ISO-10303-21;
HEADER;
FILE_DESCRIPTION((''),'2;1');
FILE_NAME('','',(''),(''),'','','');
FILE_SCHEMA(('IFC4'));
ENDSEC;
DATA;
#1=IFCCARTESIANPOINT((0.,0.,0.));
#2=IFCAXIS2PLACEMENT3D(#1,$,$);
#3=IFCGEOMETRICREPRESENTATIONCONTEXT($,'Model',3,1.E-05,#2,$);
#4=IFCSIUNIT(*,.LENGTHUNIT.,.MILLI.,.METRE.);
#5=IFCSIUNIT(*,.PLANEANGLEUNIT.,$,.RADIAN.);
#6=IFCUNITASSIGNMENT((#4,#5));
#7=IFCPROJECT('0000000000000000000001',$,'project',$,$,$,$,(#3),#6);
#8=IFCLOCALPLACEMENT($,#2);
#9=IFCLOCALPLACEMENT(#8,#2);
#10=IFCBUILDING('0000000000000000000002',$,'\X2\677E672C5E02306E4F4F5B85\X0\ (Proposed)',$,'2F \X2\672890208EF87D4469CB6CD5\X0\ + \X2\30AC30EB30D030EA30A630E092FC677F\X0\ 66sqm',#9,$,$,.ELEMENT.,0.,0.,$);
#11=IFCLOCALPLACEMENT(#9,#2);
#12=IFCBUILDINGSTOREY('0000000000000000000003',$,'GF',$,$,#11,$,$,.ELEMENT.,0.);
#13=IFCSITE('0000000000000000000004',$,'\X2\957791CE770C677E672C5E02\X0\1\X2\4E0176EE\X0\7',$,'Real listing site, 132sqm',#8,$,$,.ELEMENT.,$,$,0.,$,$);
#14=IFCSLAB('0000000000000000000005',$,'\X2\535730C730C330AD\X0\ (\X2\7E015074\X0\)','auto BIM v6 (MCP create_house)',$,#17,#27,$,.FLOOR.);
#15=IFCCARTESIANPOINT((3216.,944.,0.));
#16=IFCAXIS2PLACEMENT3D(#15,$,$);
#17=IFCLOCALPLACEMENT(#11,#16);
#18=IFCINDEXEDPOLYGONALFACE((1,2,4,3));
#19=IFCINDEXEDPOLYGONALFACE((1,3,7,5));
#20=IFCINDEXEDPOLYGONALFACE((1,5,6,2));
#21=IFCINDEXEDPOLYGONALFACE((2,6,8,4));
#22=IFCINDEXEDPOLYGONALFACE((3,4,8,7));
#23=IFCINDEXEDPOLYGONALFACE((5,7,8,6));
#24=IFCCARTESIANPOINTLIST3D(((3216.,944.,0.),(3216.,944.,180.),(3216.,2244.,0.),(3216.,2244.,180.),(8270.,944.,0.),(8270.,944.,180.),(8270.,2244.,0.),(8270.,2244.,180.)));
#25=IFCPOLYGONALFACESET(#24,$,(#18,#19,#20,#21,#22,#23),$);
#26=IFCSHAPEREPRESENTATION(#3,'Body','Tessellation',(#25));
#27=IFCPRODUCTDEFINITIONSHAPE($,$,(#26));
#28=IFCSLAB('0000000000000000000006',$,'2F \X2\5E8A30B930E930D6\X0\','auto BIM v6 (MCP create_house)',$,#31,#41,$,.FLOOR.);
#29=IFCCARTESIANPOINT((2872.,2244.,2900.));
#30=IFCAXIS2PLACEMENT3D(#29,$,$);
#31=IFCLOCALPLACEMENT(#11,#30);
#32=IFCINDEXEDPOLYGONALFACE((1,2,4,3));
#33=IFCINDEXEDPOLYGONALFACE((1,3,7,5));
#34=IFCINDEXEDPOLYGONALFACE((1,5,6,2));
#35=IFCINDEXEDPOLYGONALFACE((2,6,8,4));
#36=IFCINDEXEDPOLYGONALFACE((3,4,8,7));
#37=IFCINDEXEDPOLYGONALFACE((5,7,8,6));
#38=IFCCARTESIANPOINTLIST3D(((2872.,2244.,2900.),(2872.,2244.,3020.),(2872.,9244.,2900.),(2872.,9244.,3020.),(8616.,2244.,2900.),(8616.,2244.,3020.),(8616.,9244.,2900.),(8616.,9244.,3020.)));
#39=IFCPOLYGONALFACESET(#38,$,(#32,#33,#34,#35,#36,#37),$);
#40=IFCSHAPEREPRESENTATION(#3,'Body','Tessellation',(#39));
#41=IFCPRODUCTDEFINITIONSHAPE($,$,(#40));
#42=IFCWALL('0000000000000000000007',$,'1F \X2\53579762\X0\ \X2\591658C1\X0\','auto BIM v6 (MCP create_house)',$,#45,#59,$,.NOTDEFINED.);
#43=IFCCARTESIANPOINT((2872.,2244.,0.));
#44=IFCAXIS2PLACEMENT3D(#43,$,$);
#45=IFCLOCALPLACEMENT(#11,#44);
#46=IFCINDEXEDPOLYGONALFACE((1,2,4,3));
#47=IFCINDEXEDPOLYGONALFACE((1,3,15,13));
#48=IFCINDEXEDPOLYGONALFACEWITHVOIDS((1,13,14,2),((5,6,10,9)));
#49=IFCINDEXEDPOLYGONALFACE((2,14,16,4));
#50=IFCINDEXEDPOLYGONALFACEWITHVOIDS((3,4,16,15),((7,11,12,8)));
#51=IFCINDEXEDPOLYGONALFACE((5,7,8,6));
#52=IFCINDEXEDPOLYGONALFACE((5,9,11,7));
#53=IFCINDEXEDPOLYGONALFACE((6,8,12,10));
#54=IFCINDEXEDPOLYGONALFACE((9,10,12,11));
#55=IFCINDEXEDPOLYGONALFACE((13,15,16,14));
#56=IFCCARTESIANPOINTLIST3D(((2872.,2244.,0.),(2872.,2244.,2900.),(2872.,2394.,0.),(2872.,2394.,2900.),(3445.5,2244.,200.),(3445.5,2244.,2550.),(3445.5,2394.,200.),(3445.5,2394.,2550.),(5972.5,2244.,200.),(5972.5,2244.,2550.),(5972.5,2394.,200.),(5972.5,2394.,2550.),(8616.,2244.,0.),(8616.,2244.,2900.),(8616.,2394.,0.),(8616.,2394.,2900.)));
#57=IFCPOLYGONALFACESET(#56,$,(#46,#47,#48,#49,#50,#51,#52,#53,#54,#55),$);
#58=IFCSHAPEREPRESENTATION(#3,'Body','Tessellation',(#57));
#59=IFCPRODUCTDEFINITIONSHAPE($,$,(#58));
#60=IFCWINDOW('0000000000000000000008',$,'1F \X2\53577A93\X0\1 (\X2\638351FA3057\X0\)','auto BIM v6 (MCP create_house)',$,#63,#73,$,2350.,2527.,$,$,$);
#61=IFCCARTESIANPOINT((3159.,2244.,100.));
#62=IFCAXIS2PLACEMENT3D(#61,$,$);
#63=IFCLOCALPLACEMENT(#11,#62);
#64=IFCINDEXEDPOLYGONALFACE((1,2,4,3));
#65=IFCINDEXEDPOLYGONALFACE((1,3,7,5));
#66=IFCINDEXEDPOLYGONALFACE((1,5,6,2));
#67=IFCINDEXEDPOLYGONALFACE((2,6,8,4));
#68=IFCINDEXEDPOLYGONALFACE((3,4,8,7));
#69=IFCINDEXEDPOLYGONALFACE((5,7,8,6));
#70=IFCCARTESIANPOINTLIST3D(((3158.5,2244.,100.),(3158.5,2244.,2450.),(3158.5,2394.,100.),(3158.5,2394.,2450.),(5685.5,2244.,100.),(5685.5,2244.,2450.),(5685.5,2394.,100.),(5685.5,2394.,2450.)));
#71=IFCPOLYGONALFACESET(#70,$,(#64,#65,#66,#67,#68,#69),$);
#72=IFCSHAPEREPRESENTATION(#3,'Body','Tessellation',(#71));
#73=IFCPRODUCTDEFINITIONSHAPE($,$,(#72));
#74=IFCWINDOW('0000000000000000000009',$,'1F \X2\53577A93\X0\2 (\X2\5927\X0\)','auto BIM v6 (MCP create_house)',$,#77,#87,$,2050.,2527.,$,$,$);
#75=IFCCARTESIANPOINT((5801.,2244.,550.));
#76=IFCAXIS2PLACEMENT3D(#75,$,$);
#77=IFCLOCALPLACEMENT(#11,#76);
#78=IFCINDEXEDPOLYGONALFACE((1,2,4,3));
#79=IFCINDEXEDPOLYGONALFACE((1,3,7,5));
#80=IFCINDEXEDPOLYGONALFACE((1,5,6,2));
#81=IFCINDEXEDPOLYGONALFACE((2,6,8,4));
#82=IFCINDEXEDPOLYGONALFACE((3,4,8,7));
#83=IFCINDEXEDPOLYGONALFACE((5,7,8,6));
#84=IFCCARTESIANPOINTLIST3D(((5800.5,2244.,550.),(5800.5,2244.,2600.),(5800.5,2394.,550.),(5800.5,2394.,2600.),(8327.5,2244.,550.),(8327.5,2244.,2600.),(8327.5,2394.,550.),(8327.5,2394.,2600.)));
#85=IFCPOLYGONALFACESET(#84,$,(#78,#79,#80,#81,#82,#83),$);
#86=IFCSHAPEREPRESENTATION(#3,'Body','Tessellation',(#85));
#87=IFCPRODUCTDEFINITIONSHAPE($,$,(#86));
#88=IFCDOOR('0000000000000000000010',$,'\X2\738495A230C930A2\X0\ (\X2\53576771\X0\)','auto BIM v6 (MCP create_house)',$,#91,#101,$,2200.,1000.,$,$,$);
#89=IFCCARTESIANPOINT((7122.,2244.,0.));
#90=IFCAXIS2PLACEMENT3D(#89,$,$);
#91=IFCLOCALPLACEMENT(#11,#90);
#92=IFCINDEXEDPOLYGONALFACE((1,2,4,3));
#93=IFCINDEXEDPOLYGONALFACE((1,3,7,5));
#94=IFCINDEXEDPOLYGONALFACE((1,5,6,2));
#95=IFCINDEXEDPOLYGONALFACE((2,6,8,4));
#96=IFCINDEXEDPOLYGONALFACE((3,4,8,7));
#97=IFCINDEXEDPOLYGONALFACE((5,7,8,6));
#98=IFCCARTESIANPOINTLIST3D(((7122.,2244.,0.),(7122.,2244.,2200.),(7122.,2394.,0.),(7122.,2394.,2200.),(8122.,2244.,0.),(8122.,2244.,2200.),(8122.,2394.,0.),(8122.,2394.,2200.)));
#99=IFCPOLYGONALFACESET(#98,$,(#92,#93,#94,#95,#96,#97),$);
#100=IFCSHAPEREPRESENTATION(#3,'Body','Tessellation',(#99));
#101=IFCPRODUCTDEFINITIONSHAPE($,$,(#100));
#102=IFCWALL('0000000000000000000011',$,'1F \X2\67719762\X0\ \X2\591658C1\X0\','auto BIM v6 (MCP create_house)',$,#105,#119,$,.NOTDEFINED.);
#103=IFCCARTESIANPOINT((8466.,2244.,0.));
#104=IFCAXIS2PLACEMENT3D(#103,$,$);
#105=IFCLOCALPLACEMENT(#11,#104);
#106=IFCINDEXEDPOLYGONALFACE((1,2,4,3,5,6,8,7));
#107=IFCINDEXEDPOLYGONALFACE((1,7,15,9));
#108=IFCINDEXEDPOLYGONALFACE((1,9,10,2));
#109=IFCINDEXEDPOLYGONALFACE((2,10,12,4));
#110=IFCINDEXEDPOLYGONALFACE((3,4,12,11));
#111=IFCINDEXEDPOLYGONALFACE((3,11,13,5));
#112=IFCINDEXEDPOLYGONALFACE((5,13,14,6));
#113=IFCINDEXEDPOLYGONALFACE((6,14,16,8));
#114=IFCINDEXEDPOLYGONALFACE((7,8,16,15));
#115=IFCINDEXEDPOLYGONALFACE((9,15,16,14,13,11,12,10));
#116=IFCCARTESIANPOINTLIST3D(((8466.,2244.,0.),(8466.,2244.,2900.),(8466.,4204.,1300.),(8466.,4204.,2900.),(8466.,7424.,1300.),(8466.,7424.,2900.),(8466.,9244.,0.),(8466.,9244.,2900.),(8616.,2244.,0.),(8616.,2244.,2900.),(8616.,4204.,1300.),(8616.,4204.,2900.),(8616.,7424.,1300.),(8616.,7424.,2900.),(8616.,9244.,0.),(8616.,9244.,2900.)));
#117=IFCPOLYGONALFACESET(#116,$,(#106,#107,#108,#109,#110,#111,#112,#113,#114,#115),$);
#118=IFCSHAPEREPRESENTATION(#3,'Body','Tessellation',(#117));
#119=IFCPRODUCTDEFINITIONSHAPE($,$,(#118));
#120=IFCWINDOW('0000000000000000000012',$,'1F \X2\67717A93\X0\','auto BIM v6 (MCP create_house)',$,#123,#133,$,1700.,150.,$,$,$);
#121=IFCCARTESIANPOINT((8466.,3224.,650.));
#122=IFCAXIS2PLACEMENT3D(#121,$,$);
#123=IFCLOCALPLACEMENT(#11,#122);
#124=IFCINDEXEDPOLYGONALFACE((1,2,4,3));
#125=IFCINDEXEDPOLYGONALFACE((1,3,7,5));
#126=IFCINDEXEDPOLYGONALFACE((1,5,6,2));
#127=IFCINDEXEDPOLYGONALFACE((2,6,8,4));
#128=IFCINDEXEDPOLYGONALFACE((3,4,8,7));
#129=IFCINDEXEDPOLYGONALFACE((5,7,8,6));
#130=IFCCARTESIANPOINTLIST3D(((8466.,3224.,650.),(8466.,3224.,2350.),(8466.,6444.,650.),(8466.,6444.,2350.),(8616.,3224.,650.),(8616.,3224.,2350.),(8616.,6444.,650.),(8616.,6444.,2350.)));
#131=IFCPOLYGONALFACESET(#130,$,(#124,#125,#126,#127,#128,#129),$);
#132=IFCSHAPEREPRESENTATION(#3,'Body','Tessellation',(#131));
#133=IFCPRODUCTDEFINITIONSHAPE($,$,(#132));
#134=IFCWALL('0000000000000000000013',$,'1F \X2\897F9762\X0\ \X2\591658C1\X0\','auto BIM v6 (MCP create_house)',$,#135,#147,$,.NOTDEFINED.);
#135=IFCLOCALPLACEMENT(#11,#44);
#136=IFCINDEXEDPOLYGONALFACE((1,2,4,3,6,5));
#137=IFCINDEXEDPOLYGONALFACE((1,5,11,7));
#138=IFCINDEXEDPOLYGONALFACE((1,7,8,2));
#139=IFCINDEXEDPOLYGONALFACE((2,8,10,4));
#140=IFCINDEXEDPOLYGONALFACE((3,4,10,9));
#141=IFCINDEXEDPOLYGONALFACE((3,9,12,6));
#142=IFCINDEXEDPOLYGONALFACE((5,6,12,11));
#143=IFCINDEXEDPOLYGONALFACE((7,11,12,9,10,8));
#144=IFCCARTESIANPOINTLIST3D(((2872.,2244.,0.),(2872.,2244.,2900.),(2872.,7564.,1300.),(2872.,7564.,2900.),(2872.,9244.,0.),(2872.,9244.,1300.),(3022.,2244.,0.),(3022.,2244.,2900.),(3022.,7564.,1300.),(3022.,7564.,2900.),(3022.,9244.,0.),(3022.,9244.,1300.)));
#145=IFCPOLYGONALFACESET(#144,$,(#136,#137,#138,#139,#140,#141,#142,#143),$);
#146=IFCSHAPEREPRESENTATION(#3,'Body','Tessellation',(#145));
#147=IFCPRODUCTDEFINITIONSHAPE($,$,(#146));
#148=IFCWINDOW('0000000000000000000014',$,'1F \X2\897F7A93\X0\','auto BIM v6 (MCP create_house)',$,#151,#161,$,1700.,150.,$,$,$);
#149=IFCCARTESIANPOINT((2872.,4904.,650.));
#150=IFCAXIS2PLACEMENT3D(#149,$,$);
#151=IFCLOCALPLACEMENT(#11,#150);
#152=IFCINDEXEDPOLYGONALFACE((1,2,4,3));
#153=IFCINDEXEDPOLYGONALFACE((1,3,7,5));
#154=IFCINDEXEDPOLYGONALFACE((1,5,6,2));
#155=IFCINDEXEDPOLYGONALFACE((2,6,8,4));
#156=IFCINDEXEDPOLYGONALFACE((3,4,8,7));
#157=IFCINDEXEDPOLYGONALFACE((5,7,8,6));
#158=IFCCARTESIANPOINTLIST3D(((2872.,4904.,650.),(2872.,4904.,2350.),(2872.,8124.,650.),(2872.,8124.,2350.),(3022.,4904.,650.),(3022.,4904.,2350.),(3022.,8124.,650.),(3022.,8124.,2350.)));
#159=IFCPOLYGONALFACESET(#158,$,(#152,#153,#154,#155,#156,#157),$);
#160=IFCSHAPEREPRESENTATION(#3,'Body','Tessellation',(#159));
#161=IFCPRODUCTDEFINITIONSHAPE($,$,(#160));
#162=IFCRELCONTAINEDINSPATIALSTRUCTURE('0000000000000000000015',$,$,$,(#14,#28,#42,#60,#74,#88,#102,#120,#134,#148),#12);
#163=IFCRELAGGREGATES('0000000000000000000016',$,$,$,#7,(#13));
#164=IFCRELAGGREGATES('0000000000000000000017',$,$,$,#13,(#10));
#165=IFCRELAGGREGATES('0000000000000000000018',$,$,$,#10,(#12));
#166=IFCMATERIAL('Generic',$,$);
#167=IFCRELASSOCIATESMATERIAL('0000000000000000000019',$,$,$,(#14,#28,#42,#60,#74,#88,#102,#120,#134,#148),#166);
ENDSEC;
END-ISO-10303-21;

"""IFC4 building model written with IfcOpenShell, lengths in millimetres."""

from ifc_helpers import new_model, si_unit, frame, frame_2d, origin, place, context, project, spatial, rectangle, extrude, material, element, fill, save


model = new_model("IFC4")

# Units and contexts
model_context = context("Model", 3, precision=1e-05, world=origin())
ifc_project = project(units=[si_unit("LENGTHUNIT", "METRE", prefix="MILLI"), si_unit("PLANEANGLEUNIT", "RADIAN")], contexts=[model_context])

# Site, building, storey
site_placement = place(None, origin())
site = spatial("IfcSite", under=ifc_project, at=site_placement, Name="長野県松本市1丁目7", ObjectType="Real listing site, 132sqm", CompositionType="ELEMENT", RefElevation=0.0)
building_placement = place(site_placement, origin())
building = spatial("IfcBuilding", under=site, at=building_placement, Name="松本市の住宅 (Proposed)", ObjectType="2F 木造軸組構法 + ガルバリウム鋼板 66sqm", CompositionType="ELEMENT", ElevationOfRefHeight=0.0, ElevationOfTerrain=0.0)
storey_placement = place(building_placement, origin())
storey = spatial("IfcBuildingStorey", under=building, at=storey_placement, Name="GF", CompositionType="ELEMENT", Elevation=0.0)

# Slabs
ifc_material = material(Name="Generic")
slab_1_placement = place(storey_placement, frame((3216.0, 944.0, 0.0)))
element("IfcSlab", 1, at=slab_1_placement, inside=storey, material=ifc_material, Name="南デッキ (縁側)", Description="auto BIM v6 (MCP create_house)", PredefinedType="FLOOR", context=model_context, shape_type="SweptSolid", body=[
    extrude(rectangle(XDim=5054.0, YDim=1300.0, at=frame_2d((2527.0, 650.0))), frame((3216.0, 944.0, 0.0)), (0.0, 0.0, 1.0), 180.0),
])
slab_2_placement = place(storey_placement, frame((2872.0, 2244.0, 2900.0)))
element("IfcSlab", 2, at=slab_2_placement, inside=storey, material=ifc_material, Name="2F 床スラブ", Description="auto BIM v6 (MCP create_house)", PredefinedType="FLOOR", context=model_context, shape_type="SweptSolid", body=[
    extrude(rectangle(XDim=5744.0, YDim=7000.0, at=frame_2d((2872.0, 3500.0))), frame((2872.0, 2244.0, 2900.0)), (0.0, 0.0, 1.0), 120.0),
])

# Wall, openings, windows, door
wall_1_placement = place(storey_placement, frame((2872.0, 2244.0, 0.0)))
wall_1 = element("IfcWall", 3, at=wall_1_placement, inside=storey, material=ifc_material, Name="1F 南面 外壁", Description="auto BIM v6 (MCP create_house)", PredefinedType="NOTDEFINED", context=model_context, shape_type="SweptSolid", body=[
    extrude(rectangle(XDim=5744.0, YDim=150.0, at=frame_2d((2872.0, 75.0))), frame((2872.0, 2244.0, 0.0)), (0.0, 0.0, 1.0), 2900.0),
])
opening_1_placement = place(storey_placement, frame((3159.0, 2244.0, 100.0)))
opening_1 = element("IfcOpeningElement", 4, at=opening_1_placement, cuts=wall_1, PredefinedType="NOTDEFINED", context=model_context, shape_type="SweptSolid", body=[
    extrude(rectangle(XDim=2527.0, YDim=150.0, at=frame_2d((1263.0, 75.0))), frame((3159.0, 2244.0, 100.0)), (0.0, 0.0, 1.0), 2350.0),
])
opening_2_placement = place(storey_placement, frame((5801.0, 2244.0, 550.0)))
opening_2 = element("IfcOpeningElement", 5, at=opening_2_placement, cuts=wall_1, PredefinedType="NOTDEFINED", context=model_context, shape_type="SweptSolid", body=[
    extrude(rectangle(XDim=2527.0, YDim=150.0, at=frame_2d((1263.0, 75.0))), frame((5801.0, 2244.0, 550.0)), (0.0, 0.0, 1.0), 2050.0),
])
opening_3_placement = place(storey_placement, frame((7122.0, 2244.0, 0.0)))
opening_3 = element("IfcOpeningElement", 6, at=opening_3_placement, cuts=wall_1, PredefinedType="NOTDEFINED", context=model_context, shape_type="SweptSolid", body=[
    extrude(rectangle(XDim=1000.0, YDim=150.0, at=frame_2d((500.0, 75.0))), frame((7122.0, 2244.0, 0.0)), (0.0, 0.0, 1.0), 2200.0),
])
window_1_placement = place(storey_placement, frame((3159.0, 2244.0, 100.0)))
window_1 = element("IfcWindow", 7, at=window_1_placement, inside=storey, material=ifc_material, Name="1F 南窓1 (掃出し)", Description="auto BIM v6 (MCP create_house)", OverallHeight=2350.0, OverallWidth=2527.0, context=model_context, shape_type="SweptSolid", body=[
    extrude(rectangle(XDim=2527.0, YDim=150.0, at=frame_2d((1263.0, 75.0))), frame((3159.0, 2244.0, 100.0)), (0.0, 0.0, 1.0), 2350.0),
])
fill(opening_1, window_1)
window_2_placement = place(storey_placement, frame((5801.0, 2244.0, 550.0)))
window_2 = element("IfcWindow", 8, at=window_2_placement, inside=storey, material=ifc_material, Name="1F 南窓2 (大)", Description="auto BIM v6 (MCP create_house)", OverallHeight=2050.0, OverallWidth=2527.0, context=model_context, shape_type="SweptSolid", body=[
    extrude(rectangle(XDim=2527.0, YDim=150.0, at=frame_2d((1263.0, 75.0))), frame((5801.0, 2244.0, 550.0)), (0.0, 0.0, 1.0), 2050.0),
])
fill(opening_2, window_2)
door_placement = place(storey_placement, frame((7122.0, 2244.0, 0.0)))
door = element("IfcDoor", 9, at=door_placement, inside=storey, material=ifc_material, Name="玄関ドア (南東)", Description="auto BIM v6 (MCP create_house)", OverallHeight=2200.0, OverallWidth=1000.0, context=model_context, shape_type="SweptSolid", body=[
    extrude(rectangle(XDim=1000.0, YDim=150.0, at=frame_2d((500.0, 75.0))), frame((7122.0, 2244.0, 0.0)), (0.0, 0.0, 1.0), 2200.0),
])
fill(opening_3, door)

# Walls, openings, windows
wall_2_placement = place(storey_placement, frame((8466.0, 2244.0, 0.0)))
wall_2 = element("IfcWall", 10, at=wall_2_placement, inside=storey, material=ifc_material, Name="1F 東面 外壁", Description="auto BIM v6 (MCP create_house)", PredefinedType="NOTDEFINED", context=model_context, shape_type="SweptSolid", body=[
    extrude(rectangle(XDim=150.0, YDim=7000.0, at=frame_2d((75.0, 3500.0))), frame((8466.0, 2244.0, 0.0)), (0.0, 0.0, 1.0), 2900.0),
])
opening_4_placement = place(storey_placement, frame((8466.0, 3224.0, 650.0)))
opening_4 = element("IfcOpeningElement", 11, at=opening_4_placement, cuts=wall_2, PredefinedType="NOTDEFINED", context=model_context, shape_type="SweptSolid", body=[
    extrude(rectangle(XDim=150.0, YDim=3220.0, at=frame_2d((75.0, 1610.0))), frame((8466.0, 3224.0, 650.0)), (0.0, 0.0, 1.0), 1700.0),
])
window_3_placement = place(storey_placement, frame((8466.0, 3224.0, 650.0)))
window_3 = element("IfcWindow", 12, at=window_3_placement, inside=storey, material=ifc_material, Name="1F 東窓", Description="auto BIM v6 (MCP create_house)", OverallHeight=1700.0, OverallWidth=150.0, context=model_context, shape_type="SweptSolid", body=[
    extrude(rectangle(XDim=150.0, YDim=3220.0, at=frame_2d((75.0, 1610.0))), frame((8466.0, 3224.0, 650.0)), (0.0, 0.0, 1.0), 1700.0),
])
fill(opening_4, window_3)
wall_3_placement = place(storey_placement, frame((2872.0, 2244.0, 0.0)))
wall_3 = element("IfcWall", 13, at=wall_3_placement, inside=storey, material=ifc_material, Name="1F 西面 外壁", Description="auto BIM v6 (MCP create_house)", PredefinedType="NOTDEFINED", context=model_context, shape_type="SweptSolid", body=[
    extrude(rectangle(XDim=150.0, YDim=7000.0, at=frame_2d((75.0, 3500.0))), frame((2872.0, 2244.0, 0.0)), (0.0, 0.0, 1.0), 2900.0),
])
opening_5_placement = place(storey_placement, frame((2872.0, 4904.0, 650.0)))
opening_5 = element("IfcOpeningElement", 14, at=opening_5_placement, cuts=wall_3, PredefinedType="NOTDEFINED", context=model_context, shape_type="SweptSolid", body=[
    extrude(rectangle(XDim=150.0, YDim=3220.0, at=frame_2d((75.0, 1610.0))), frame((2872.0, 4904.0, 650.0)), (0.0, 0.0, 1.0), 1700.0),
])
window_4_placement = place(storey_placement, frame((2872.0, 4904.0, 650.0)))
window_4 = element("IfcWindow", 15, at=window_4_placement, inside=storey, material=ifc_material, Name="1F 西窓", Description="auto BIM v6 (MCP create_house)", OverallHeight=1700.0, OverallWidth=150.0, context=model_context, shape_type="SweptSolid", body=[
    extrude(rectangle(XDim=150.0, YDim=3220.0, at=frame_2d((75.0, 1610.0))), frame((2872.0, 4904.0, 650.0)), (0.0, 0.0, 1.0), 1700.0),
])
fill(opening_5, window_4)

save(model, "model.ifc")
